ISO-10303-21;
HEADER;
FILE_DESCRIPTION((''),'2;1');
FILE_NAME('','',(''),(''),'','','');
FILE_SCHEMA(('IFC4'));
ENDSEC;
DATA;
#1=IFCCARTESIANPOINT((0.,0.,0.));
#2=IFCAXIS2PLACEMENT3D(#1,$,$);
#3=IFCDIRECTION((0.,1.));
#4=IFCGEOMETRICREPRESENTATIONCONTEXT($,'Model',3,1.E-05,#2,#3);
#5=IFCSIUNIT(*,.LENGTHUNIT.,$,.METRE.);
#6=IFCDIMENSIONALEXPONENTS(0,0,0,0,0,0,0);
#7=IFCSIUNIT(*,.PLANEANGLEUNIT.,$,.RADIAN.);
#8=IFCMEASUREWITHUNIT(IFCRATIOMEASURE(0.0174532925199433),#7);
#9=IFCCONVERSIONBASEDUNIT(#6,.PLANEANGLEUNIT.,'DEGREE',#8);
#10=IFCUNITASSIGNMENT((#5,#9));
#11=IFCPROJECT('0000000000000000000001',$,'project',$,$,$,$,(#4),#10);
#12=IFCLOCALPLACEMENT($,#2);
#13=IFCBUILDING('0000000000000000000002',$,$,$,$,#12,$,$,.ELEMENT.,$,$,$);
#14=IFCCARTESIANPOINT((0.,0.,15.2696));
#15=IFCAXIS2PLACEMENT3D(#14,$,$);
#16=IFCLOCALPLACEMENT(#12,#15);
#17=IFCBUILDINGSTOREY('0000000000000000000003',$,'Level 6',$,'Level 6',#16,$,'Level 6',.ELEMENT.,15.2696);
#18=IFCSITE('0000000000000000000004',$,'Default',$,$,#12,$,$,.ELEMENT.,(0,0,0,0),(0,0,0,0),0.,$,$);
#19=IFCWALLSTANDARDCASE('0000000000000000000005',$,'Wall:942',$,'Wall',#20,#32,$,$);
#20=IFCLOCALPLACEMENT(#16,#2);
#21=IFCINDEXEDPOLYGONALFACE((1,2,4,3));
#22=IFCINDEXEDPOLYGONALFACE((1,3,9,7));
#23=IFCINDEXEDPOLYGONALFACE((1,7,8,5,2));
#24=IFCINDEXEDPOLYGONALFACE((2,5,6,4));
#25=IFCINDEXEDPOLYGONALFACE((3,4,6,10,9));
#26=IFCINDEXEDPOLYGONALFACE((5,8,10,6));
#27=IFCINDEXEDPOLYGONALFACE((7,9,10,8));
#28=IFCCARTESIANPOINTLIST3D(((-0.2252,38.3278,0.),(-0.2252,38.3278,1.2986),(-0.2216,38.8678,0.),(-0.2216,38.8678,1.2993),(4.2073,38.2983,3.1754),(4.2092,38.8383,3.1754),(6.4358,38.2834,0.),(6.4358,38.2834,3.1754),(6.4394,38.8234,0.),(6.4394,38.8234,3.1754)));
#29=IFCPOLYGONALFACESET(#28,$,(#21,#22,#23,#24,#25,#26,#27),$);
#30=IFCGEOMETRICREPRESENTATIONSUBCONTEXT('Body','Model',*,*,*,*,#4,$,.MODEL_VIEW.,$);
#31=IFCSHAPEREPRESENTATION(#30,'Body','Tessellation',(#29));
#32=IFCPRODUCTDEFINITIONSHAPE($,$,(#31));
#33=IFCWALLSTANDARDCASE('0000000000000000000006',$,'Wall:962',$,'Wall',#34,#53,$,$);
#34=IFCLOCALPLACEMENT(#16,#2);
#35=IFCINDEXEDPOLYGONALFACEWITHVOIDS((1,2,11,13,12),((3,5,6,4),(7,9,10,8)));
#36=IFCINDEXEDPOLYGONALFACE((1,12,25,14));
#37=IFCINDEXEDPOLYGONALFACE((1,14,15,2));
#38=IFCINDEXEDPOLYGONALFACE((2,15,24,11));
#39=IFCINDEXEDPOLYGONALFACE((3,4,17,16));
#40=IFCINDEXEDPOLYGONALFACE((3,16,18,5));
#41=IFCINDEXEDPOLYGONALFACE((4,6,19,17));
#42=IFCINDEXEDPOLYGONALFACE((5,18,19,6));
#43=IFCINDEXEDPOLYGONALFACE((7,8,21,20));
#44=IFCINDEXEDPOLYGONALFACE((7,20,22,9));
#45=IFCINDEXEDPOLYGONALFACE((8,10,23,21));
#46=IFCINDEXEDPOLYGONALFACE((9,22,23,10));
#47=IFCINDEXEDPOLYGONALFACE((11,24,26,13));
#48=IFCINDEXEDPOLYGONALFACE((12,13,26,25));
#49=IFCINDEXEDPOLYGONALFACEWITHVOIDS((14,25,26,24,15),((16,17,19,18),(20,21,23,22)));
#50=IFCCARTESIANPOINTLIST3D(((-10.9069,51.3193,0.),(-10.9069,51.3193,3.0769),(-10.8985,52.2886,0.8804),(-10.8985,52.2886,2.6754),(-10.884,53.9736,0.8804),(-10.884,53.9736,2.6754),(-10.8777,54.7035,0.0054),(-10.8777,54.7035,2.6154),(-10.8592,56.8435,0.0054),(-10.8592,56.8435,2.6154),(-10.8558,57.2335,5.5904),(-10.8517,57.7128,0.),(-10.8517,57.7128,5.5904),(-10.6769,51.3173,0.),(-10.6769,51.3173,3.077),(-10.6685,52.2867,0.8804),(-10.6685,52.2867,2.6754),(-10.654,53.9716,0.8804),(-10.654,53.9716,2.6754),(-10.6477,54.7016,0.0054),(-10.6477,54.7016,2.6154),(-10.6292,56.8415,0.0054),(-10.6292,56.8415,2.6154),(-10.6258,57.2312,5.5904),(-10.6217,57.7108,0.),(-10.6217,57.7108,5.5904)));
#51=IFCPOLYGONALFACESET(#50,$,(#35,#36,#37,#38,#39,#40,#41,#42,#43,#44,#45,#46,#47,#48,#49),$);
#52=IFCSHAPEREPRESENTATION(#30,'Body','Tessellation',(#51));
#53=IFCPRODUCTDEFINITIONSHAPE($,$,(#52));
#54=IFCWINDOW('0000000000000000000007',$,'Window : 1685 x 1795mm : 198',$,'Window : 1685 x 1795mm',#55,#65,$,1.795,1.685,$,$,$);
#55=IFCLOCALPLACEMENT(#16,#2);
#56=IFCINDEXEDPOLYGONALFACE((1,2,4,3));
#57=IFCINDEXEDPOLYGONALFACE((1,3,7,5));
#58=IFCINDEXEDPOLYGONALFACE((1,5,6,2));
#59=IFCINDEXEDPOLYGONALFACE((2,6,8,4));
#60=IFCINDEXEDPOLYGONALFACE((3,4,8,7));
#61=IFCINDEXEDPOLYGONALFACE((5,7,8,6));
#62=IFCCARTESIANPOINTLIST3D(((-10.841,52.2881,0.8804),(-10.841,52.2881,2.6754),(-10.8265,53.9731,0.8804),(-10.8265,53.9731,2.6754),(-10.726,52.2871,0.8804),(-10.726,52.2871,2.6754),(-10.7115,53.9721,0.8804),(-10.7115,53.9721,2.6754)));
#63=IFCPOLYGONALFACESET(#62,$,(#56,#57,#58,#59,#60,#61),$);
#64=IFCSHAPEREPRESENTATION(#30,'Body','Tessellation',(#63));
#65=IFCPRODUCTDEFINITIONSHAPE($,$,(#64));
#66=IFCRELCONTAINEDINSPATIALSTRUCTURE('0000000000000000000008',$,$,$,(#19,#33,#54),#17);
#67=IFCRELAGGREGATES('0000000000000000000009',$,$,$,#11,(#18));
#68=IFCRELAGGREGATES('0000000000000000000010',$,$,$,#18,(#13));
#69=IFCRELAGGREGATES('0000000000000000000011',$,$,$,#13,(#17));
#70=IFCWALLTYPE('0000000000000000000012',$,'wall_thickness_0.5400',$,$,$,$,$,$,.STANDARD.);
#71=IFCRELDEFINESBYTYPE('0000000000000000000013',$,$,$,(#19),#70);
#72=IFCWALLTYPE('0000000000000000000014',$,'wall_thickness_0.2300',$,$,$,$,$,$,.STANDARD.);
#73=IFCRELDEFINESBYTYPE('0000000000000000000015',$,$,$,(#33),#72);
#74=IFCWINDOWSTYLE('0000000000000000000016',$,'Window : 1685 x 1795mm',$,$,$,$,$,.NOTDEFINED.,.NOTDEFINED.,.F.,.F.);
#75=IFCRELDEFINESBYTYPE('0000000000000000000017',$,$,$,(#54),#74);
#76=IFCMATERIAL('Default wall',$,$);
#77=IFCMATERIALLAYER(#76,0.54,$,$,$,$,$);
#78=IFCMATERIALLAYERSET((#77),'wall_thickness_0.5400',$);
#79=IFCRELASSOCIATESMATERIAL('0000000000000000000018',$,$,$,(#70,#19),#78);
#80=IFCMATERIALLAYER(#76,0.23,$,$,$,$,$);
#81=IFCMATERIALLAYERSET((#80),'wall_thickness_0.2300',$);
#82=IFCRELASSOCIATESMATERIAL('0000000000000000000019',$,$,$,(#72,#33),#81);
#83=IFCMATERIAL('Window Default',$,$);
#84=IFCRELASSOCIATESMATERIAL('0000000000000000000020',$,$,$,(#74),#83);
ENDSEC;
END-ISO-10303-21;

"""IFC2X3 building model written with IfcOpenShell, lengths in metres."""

from ifc_helpers import new_model, entity, si_unit, converted_unit, direction, frame, frame_2d, origin, origin_2d_with_axis, place, context, subcontext, project, spatial, polyline, rectangle, outline, extrude, clip, halfspace, source, transform, mapped, material, layer, layer_set, layer_usage, type_object, type_shapes, element, fill, save


model = new_model("IFC2X3")

# Units and contexts
model_context = context("Model", 3, precision=1e-05, world=origin(), true_north=direction((0.0, 1.0)))
body_context = subcontext(model_context, "Body", "Model", "MODEL_VIEW")
ifc_project = project(units=[si_unit("LENGTHUNIT", "METRE"), converted_unit("PLANEANGLEUNIT", "DEGREE", entity("IfcRatioMeasure", 0.0174532925199433), si_unit("PLANEANGLEUNIT", "RADIAN"), dimensions=[0, 0, 0, 0, 0, 0, 0])], contexts=[model_context])

# Site, building, storey
placement = place(None, origin())
site = spatial("IfcSite", under=ifc_project, at=placement, Name="Default", CompositionType="ELEMENT", RefLatitude=(0, 0, 0, 0), RefLongitude=(0, 0, 0, 0), RefElevation=0.0)
building = spatial("IfcBuilding", under=site, at=placement, CompositionType="ELEMENT")
storey_placement = place(placement, frame((0.0, 0.0, 15.2696)))
storey = spatial("IfcBuildingStorey", under=building, at=storey_placement, Name="Level 6", ObjectType="Level 6", LongName="Level 6", CompositionType="ELEMENT", Elevation=15.2696)

# Shared definitions
ifc_material_1 = material(Name="Default wall")

# Shared definitions
ifc_material_2 = material(Name="Window Default")

# Wall
ifc_layer_1 = layer(ifc_material_1, 0.54)
ifc_layer_set_1 = layer_set([ifc_layer_1], Name="wall_thickness_0.5400")
ifc_layer_usage_1 = layer_usage(ifc_layer_set_1, "AXIS2", "POSITIVE", -0.27)
wall_type_1 = type_object("IfcWallType", Name="wall_thickness_0.5400", PredefinedType="STANDARD", material=ifc_layer_set_1)
wall_1_placement = place(storey_placement, frame((-0.2234, 38.5978, 0.0), z_axis=(0.0, 0.0, 1.0), x_axis=(0.999978, -0.006658, 0.0)))
element("IfcWallStandardCase", 1, at=wall_1_placement, inside=storey, type_object=wall_type_1, material=ifc_layer_usage_1, Name="Wall:942", ObjectType="Wall", context=body_context, shape_type="Clipping", body=[
    clip(extrude(outline(polyline([(6.6612, -0.27), (6.6612, 0.27), (0.0, 0.27), (0.0, -0.27), (6.6612, -0.27)])), origin(), (0.0, 0.0, 1.0), 3.1754), halfspace(frame((-1.2512, 37.2424, 0.817), z_axis=(-0.389902, -0.001181, 0.920856), x_axis=(0.920855, 0.000578, 0.389905)), False)),
])

# Wall, openings, window
ifc_layer_2 = layer(ifc_material_1, 0.23)
ifc_layer_set_2 = layer_set([ifc_layer_2], Name="wall_thickness_0.2300")
ifc_layer_usage_2 = layer_usage(ifc_layer_set_2, "AXIS2", "POSITIVE", -0.115)
wall_type_2 = type_object("IfcWallType", Name="wall_thickness_0.2300", PredefinedType="STANDARD", material=ifc_layer_set_2)
wall_2_placement = place(storey_placement, frame((-10.7367, 57.7118, 0.0), z_axis=(0.0, 0.0, 1.0), x_axis=(-0.00864, -0.999963, 0.0)))
wall_2 = element("IfcWallStandardCase", 2, at=wall_2_placement, inside=storey, type_object=wall_type_2, material=ifc_layer_usage_2, Name="Wall:962", ObjectType="Wall", context=body_context, shape_type="Clipping", body=[
    clip(extrude(outline(polyline([(6.3937, -0.115), (6.3937, 0.115), (0.0, 0.115), (0.0, -0.115), (6.3937, -0.115)])), origin(), (0.0, 0.0, 1.0), 5.5904), halfspace(frame((-0.0779, -2.0173, 5.8262), z_axis=(0.391128, -0.000505, 0.920336), x_axis=(-0.000494, 1.0, 0.000759)), False)),
])
opening_1_placement = place(wall_2_placement, frame((0.8693, -0.115, 0.0054)))
element("IfcOpeningElement", 3, at=opening_1_placement, cuts=wall_2, ObjectType="Opening", context=body_context, shape_type="SweptSolid", body=[
    extrude(rectangle(XDim=2.14, YDim=2.61, at=frame_2d((1.305, 1.07), x_axis=(0.0, 1.0))), frame((0.0, 0.0, 0.0), z_axis=(0.0, 1.0, 0.0), x_axis=(0.0, 0.0, 1.0)), (0.0, 0.0, 1.0), 0.23),
])
opening_2_placement = place(wall_2_placement, frame((3.7393, -0.115, 0.8804)))
opening_2 = element("IfcOpeningElement", 4, at=opening_2_placement, cuts=wall_2, ObjectType="Opening", context=body_context, shape_type="SweptSolid", body=[
    extrude(rectangle(XDim=1.685, YDim=1.795, at=frame_2d((0.8975, 0.8425), x_axis=(0.0, 1.0))), frame((0.0, 0.0, 0.0), z_axis=(0.0, 1.0, 0.0), x_axis=(0.0, 0.0, 1.0)), (0.0, 0.0, 1.0), 0.23),
])
window_style_1 = type_object("IfcWindowStyle", Name="Window : 1685 x 1795mm", ConstructionType="NOTDEFINED", OperationType="NOTDEFINED", ParameterTakesPrecedence=False, Sizeable=False, material=ifc_material_2)
shared_shape_1 = source(origin(), body_context, "Body", "SweptSolid", [
    extrude(rectangle(XDim=0.115, YDim=1.685, at=origin_2d_with_axis()), frame((0.8425, 0.115, 0.0), z_axis=(0.0, 0.0, 1.0), x_axis=(0.0, 1.0, 0.0)), (0.0, 0.0, 1.0), 1.795),
])
type_shapes(window_style_1, [shared_shape_1])
window_1_placement = place(opening_2_placement, origin())
window_1 = element("IfcWindow", 5, at=window_1_placement, inside=storey, type_object=window_style_1, Name="Window : 1685 x 1795mm : 198", ObjectType="Window : 1685 x 1795mm", OverallHeight=1.795, OverallWidth=1.685, context=body_context, shape_type="MappedRepresentation", body=[
    mapped(shared_shape_1, transform((0.0, 0.0, 0.0), scale=1.0)),
])
fill(opening_2, window_1)

save(model, "model.ifc")
